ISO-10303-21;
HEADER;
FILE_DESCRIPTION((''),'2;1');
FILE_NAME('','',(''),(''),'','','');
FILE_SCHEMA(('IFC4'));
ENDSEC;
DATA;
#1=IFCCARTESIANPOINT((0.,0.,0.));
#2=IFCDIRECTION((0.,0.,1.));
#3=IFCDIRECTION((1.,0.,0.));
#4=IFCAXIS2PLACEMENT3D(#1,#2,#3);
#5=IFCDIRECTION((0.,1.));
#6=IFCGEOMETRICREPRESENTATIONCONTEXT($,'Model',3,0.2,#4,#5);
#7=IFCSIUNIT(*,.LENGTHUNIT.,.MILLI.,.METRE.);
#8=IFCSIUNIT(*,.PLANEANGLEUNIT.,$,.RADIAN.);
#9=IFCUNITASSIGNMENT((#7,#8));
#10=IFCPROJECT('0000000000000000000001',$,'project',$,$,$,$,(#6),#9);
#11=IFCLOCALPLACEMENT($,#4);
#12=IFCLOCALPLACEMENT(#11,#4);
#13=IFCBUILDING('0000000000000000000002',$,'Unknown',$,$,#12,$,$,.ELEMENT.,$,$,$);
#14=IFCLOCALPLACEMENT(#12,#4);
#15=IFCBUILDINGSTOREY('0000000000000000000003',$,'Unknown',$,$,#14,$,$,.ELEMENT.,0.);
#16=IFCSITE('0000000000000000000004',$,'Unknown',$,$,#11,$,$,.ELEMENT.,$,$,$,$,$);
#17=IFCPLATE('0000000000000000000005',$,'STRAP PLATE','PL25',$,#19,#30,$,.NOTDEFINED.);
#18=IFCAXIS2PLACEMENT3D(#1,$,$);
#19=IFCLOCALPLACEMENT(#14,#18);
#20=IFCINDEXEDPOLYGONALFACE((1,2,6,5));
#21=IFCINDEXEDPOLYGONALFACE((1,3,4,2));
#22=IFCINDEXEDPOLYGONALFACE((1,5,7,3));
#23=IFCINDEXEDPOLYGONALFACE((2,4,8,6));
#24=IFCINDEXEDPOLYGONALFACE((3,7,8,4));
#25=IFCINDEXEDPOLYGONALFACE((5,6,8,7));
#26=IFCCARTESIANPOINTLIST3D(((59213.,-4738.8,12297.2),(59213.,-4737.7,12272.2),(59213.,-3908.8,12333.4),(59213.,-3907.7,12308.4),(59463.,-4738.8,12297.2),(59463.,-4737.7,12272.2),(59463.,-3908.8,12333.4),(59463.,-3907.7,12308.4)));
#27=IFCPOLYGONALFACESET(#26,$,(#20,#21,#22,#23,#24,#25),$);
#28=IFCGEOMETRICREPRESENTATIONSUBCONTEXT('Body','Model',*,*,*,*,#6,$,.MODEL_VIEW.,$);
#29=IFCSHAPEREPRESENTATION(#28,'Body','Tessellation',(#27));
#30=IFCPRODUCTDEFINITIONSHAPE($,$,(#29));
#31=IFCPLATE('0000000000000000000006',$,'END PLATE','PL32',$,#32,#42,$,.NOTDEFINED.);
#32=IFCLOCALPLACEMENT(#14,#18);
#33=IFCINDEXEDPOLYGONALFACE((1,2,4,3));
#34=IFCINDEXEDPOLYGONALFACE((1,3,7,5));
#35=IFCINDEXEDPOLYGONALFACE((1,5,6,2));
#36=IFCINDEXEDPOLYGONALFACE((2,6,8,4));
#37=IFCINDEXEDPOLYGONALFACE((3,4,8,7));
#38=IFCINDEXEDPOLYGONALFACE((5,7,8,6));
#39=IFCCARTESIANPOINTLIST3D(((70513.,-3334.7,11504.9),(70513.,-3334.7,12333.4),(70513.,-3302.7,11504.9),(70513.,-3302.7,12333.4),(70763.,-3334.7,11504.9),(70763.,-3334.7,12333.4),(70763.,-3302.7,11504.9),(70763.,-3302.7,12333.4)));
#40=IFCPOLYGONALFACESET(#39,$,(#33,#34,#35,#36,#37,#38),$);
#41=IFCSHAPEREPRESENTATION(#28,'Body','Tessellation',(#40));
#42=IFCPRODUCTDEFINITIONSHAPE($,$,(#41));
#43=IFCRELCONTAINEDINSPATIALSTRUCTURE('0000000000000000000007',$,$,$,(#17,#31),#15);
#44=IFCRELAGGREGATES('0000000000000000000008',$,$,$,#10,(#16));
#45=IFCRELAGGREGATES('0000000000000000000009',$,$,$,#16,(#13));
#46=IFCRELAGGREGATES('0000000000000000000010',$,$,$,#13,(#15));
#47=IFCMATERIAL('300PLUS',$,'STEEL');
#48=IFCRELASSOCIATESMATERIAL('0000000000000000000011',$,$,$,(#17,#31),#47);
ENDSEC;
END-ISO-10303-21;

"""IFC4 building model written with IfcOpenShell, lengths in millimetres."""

from ifc_helpers import new_model, si_unit, direction, frame, origin_with_axes, place, context, subcontext, project, spatial, line, indexed_curve, outline, extrude, material, element, save


model = new_model("IFC4")

# Units and contexts
model_context = context("Model", 3, precision=0.2, world=origin_with_axes(), true_north=direction((0.0, 1.0)))
body_context = subcontext(model_context, "Body", "Model", "MODEL_VIEW")
ifc_project = project(units=[si_unit("LENGTHUNIT", "METRE", prefix="MILLI"), si_unit("PLANEANGLEUNIT", "RADIAN")], contexts=[model_context])

# Site, building, storey
site_placement = place(None, origin_with_axes())
site = spatial("IfcSite", under=ifc_project, at=site_placement, Name="Unknown", CompositionType="ELEMENT")
building_placement = place(site_placement, origin_with_axes())
building = spatial("IfcBuilding", under=site, at=building_placement, Name="Unknown", CompositionType="ELEMENT")
storey_placement = place(building_placement, origin_with_axes())
storey = spatial("IfcBuildingStorey", under=building, at=storey_placement, Name="Unknown", CompositionType="ELEMENT", Elevation=0.0)

# Shared definitions
ifc_material_1 = material(Name="300PLUS", Category="STEEL")

# Plates
plate_1_placement = place(storey_placement, frame((59463.0, -4738.2, 12284.7), z_axis=(0.0, -0.043573, 0.99905), x_axis=(0.0, 0.99905, 0.043573)))
element("IfcPlate", 1, at=plate_1_placement, inside=storey, material=ifc_material_1, Name="STRAP PLATE", Description="PL25", PredefinedType="NOTDEFINED", context=body_context, shape_type="SolidModel", body=[
    extrude(outline(indexed_curve([(0.0, 0.0), (830.8, 0.0), (830.8, 250.0), (0.0, 250.0)], segments=[line(1, 2, 3, 4, 1)])), frame((0.0, 0.0, 12.5), z_axis=(0.0, 0.0, 1.0), x_axis=(1.0, 0.0, 0.0)), (0.0, 0.0, -1.0), 25.0),
])
plate_2_placement = place(storey_placement, frame((70513.0, -3318.7, 12333.4), z_axis=(0.0, 1.0, 0.0), x_axis=(1.0, 0.0, 0.0)))
element("IfcPlate", 2, at=plate_2_placement, inside=storey, material=ifc_material_1, Name="END PLATE", Description="PL32", PredefinedType="NOTDEFINED", context=body_context, shape_type="SolidModel", body=[
    extrude(outline(indexed_curve([(0.0, 0.0), (250.0, 0.0), (250.0, 828.5), (0.0, 828.5)], segments=[line(1, 2, 3, 4, 1)])), frame((0.0, 0.0, 16.0), z_axis=(0.0, 0.0, 1.0), x_axis=(1.0, 0.0, 0.0)), (0.0, 0.0, -1.0), 32.0),
])

save(model, "model.ifc")
